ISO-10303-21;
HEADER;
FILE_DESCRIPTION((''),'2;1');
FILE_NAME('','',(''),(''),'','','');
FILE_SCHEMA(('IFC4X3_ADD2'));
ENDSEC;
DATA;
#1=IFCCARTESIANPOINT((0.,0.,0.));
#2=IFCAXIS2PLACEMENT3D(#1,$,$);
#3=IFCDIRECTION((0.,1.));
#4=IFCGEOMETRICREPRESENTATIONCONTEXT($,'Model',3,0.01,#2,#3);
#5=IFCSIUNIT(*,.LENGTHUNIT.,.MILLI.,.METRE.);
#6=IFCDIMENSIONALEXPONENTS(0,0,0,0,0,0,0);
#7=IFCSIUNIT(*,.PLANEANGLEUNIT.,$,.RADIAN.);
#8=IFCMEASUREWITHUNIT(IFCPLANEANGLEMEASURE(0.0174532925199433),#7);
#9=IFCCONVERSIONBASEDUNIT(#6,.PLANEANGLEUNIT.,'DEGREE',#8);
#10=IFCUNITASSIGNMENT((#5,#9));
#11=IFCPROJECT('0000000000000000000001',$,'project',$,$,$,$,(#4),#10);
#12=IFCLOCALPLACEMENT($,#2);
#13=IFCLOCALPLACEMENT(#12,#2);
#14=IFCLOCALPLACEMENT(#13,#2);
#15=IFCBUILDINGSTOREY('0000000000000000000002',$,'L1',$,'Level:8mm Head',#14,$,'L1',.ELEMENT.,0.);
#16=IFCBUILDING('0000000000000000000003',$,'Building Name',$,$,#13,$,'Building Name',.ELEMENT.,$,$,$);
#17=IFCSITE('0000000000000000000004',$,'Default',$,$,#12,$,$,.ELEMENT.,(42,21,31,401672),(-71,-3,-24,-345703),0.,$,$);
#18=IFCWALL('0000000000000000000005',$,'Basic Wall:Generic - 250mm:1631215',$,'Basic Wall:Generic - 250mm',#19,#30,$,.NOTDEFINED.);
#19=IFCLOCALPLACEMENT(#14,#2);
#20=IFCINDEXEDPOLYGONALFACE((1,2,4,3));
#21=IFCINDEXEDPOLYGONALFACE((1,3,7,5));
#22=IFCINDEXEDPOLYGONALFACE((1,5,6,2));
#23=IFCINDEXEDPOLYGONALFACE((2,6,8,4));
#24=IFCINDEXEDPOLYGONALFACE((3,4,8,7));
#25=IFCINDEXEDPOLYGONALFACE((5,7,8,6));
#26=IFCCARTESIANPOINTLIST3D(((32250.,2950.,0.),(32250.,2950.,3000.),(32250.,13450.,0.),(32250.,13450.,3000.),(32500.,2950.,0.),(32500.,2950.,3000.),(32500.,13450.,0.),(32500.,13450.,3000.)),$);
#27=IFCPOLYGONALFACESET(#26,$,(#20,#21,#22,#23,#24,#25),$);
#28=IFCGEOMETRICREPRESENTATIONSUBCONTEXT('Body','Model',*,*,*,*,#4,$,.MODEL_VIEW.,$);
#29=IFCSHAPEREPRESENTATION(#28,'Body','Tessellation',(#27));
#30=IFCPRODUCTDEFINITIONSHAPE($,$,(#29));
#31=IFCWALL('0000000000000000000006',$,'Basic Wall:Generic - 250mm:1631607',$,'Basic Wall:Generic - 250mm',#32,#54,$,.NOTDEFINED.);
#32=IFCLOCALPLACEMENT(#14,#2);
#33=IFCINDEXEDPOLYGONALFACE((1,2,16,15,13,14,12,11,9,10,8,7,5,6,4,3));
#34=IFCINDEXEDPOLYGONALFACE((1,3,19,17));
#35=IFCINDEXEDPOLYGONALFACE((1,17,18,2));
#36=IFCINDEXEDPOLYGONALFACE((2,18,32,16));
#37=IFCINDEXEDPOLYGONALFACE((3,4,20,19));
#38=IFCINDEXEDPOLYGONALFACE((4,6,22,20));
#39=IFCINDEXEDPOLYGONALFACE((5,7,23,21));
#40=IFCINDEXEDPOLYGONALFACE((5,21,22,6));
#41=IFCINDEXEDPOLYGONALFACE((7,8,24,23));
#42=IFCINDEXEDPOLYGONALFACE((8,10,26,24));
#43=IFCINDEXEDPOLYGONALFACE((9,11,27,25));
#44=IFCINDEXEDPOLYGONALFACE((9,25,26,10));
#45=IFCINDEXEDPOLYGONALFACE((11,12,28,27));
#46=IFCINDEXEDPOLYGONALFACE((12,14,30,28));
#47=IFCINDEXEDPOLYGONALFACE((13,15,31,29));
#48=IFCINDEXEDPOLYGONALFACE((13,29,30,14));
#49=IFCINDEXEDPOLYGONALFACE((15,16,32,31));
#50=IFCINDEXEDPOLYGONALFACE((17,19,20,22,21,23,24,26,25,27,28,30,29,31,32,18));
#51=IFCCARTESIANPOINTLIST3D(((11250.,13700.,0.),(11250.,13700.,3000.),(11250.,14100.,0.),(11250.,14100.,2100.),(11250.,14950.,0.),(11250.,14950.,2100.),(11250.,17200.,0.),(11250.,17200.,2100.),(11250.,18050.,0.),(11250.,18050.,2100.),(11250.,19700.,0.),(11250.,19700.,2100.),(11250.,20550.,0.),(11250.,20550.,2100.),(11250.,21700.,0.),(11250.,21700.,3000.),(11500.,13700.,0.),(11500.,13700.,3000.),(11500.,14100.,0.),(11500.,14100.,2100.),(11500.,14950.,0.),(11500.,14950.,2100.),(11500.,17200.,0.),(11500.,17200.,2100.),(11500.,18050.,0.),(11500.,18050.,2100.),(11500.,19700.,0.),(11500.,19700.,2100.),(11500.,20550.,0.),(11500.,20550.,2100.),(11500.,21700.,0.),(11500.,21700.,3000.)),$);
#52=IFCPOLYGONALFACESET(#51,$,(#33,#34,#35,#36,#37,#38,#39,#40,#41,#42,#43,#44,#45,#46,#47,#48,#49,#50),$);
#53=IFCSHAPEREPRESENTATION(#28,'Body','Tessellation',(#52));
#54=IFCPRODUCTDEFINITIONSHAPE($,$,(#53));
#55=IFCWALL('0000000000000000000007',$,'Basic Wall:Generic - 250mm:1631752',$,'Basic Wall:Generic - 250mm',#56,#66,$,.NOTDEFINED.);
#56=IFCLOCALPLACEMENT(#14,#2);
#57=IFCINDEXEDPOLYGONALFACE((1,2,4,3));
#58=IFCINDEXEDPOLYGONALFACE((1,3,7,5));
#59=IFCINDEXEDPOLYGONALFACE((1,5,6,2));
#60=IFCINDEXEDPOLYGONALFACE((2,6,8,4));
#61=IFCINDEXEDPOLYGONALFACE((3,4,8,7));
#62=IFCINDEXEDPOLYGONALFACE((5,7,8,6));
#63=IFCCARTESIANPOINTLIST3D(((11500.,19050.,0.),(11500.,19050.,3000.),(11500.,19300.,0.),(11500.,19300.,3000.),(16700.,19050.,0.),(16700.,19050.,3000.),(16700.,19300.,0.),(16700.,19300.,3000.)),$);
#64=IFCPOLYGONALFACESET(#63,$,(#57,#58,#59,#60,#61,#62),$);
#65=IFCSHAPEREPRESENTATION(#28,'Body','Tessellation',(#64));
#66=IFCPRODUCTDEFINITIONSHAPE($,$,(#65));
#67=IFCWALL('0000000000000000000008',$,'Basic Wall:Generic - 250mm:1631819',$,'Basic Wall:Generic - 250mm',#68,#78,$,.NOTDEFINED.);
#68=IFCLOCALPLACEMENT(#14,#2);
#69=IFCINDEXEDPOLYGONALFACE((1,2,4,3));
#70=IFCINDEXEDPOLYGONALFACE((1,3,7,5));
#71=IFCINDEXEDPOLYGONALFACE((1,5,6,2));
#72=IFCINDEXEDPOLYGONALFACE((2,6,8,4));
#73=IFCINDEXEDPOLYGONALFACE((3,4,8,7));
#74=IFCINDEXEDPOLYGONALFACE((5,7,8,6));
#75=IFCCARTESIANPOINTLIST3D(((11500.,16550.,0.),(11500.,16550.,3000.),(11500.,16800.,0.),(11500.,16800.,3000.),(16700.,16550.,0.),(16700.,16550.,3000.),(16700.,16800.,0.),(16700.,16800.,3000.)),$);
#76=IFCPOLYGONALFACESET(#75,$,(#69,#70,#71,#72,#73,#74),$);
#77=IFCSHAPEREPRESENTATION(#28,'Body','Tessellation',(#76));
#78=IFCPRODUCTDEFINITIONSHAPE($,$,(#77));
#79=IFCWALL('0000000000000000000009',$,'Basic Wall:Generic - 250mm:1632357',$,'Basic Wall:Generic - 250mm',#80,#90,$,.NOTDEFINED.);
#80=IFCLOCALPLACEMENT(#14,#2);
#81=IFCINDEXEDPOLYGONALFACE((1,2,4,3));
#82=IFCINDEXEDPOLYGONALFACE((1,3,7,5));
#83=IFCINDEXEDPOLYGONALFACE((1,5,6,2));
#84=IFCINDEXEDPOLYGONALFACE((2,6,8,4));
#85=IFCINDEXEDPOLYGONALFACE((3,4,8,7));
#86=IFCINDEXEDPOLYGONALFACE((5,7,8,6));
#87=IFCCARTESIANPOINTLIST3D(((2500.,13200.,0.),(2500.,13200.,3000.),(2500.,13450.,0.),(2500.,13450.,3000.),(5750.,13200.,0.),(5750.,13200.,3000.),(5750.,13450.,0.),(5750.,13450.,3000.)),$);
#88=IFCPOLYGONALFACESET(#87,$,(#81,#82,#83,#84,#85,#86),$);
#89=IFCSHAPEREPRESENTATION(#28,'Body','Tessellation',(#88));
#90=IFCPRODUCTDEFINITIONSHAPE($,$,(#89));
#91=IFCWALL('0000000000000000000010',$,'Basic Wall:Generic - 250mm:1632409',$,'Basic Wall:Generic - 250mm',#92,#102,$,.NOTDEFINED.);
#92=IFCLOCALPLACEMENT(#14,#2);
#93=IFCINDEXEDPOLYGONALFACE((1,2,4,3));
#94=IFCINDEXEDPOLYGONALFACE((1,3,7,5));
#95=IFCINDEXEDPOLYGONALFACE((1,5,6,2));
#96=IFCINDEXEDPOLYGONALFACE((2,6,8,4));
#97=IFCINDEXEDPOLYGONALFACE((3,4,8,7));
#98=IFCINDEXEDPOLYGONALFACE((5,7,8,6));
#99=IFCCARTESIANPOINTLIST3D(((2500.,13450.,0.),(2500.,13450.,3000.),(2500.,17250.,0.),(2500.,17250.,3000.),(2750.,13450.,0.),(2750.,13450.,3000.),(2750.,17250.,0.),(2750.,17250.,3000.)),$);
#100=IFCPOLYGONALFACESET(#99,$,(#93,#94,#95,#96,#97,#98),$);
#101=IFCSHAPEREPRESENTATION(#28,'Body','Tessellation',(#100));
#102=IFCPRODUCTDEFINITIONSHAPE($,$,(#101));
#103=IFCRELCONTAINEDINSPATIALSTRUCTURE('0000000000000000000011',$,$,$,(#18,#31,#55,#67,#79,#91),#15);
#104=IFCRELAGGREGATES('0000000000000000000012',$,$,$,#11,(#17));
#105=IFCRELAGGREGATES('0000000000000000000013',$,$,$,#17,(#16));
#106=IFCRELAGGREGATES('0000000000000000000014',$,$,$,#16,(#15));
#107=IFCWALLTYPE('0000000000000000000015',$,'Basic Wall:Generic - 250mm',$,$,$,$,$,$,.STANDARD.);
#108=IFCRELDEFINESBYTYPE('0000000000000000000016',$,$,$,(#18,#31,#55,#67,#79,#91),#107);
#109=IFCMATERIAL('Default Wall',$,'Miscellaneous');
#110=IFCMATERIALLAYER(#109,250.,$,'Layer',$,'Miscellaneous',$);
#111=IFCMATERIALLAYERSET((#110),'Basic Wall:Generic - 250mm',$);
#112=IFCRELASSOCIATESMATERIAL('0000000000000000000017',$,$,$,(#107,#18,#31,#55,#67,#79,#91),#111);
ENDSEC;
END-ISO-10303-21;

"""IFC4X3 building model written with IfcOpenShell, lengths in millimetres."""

from ifc_helpers import new_model, entity, si_unit, converted_unit, direction, frame, frame_2d, origin, place, context, subcontext, project, spatial, rectangle, extrude, material, layer, layer_set, type_object, element, save


model = new_model("IFC4X3")

# Units and contexts
model_context = context("Model", 3, precision=0.01, world=origin(), true_north=direction((0.0, 1.0)))
body_context = subcontext(model_context, "Body", "Model", "MODEL_VIEW")
ifc_project = project(units=[si_unit("LENGTHUNIT", "METRE", prefix="MILLI"), converted_unit("PLANEANGLEUNIT", "DEGREE", entity("IfcPlaneAngleMeasure", 0.0174532925199433), si_unit("PLANEANGLEUNIT", "RADIAN"), dimensions=[0, 0, 0, 0, 0, 0, 0])], contexts=[model_context])

# Site, building, storey
site_placement = place(None, origin())
site = spatial("IfcSite", under=ifc_project, at=site_placement, Name="Default", CompositionType="ELEMENT", RefLatitude=(42, 21, 31, 401672), RefLongitude=(-71, -3, -24, -345703), RefElevation=0.0)
building_placement = place(site_placement, origin())
building = spatial("IfcBuilding", under=site, at=building_placement, Name="Building Name", LongName="Building Name", CompositionType="ELEMENT")
storey_placement = place(building_placement, origin())
storey = spatial("IfcBuildingStorey", under=building, at=storey_placement, Name="L1", ObjectType="Level:8mm Head", LongName="L1", CompositionType="ELEMENT", Elevation=0.0)

# Shared definitions
ifc_material = material(Name="Default Wall", Category="Miscellaneous")
ifc_layer = layer(ifc_material, 250.0, Name="Layer", Category="Miscellaneous")
ifc_layer_set = layer_set([ifc_layer], Name="Basic Wall:Generic - 250mm")
wall_type = type_object("IfcWallType", Name="Basic Wall:Generic - 250mm", PredefinedType="STANDARD", material=ifc_layer_set)

# Wall
wall_1_placement = place(storey_placement, frame((32375.0, 2950.0, 0.0), z_axis=(0.0, 0.0, 1.0), x_axis=(0.0, 1.0, 0.0)))
element("IfcWall", 1, at=wall_1_placement, inside=storey, type_object=wall_type, material=ifc_layer_set, Name="Basic Wall:Generic - 250mm:1631215", ObjectType="Basic Wall:Generic - 250mm", PredefinedType="NOTDEFINED", context=body_context, shape_type="SweptSolid", body=[
    extrude(rectangle(XDim=10500.0, YDim=250.0, at=frame_2d((5250.0, 0.0), x_axis=(-1.0, 0.0))), origin(), (0.0, 0.0, 1.0), 3000.0),
])

# Wall, openings
wall_2_placement = place(storey_placement, frame((11375.0, 13700.0, 0.0), z_axis=(0.0, 0.0, 1.0), x_axis=(0.0, 1.0, 0.0)))
wall_2 = element("IfcWall", 2, at=wall_2_placement, inside=storey, type_object=wall_type, material=ifc_layer_set, Name="Basic Wall:Generic - 250mm:1631607", ObjectType="Basic Wall:Generic - 250mm", PredefinedType="NOTDEFINED", context=body_context, shape_type="SweptSolid", body=[
    extrude(rectangle(XDim=8000.0, YDim=250.0, at=frame_2d((4000.0, 0.0), x_axis=(-1.0, 0.0))), origin(), (0.0, 0.0, 1.0), 3000.0),
])
opening_1_placement = place(wall_2_placement, frame((6850.0, 125.0, 0.0)))
element("IfcOpeningElement", 3, at=opening_1_placement, cuts=wall_2, PredefinedType="OPENING", context=body_context, shape_type="SweptSolid", body=[
    extrude(rectangle(XDim=2100.0, YDim=850.0, at=frame_2d((1050.0, 425.0), x_axis=(1.0, 0.0))), frame((0.0, 0.0, 0.0), z_axis=(0.0, -1.0, 0.0), x_axis=(0.0, 0.0, 1.0)), (0.0, 0.0, 1.0), 250.0),
])
opening_2_placement = place(wall_2_placement, frame((4350.0, 125.0, 0.0)))
element("IfcOpeningElement", 4, at=opening_2_placement, cuts=wall_2, PredefinedType="OPENING", context=body_context, shape_type="SweptSolid", body=[
    extrude(rectangle(XDim=2100.0, YDim=850.0, at=frame_2d((1050.0, 425.0), x_axis=(1.0, 0.0))), frame((0.0, 0.0, 0.0), z_axis=(0.0, -1.0, 0.0), x_axis=(0.0, 0.0, 1.0)), (0.0, 0.0, 1.0), 250.0),
])
opening_3_placement = place(wall_2_placement, frame((1250.0, 125.0, 0.0)))
element("IfcOpeningElement", 5, at=opening_3_placement, cuts=wall_2, PredefinedType="OPENING", context=body_context, shape_type="SweptSolid", body=[
    extrude(rectangle(XDim=2100.0, YDim=850.0, at=frame_2d((1050.0, 425.0), x_axis=(1.0, 0.0))), frame((0.0, 0.0, 0.0), z_axis=(0.0, -1.0, 0.0), x_axis=(0.0, 0.0, 1.0)), (0.0, 0.0, 1.0), 250.0),
])

# Walls
wall_3_placement = place(storey_placement, frame((11500.0, 19175.0, 0.0)))
element("IfcWall", 6, at=wall_3_placement, inside=storey, type_object=wall_type, material=ifc_layer_set, Name="Basic Wall:Generic - 250mm:1631752", ObjectType="Basic Wall:Generic - 250mm", PredefinedType="NOTDEFINED", context=body_context, shape_type="SweptSolid", body=[
    extrude(rectangle(XDim=5200.0, YDim=250.0, at=frame_2d((2600.0, 0.0), x_axis=(-1.0, 0.0))), origin(), (0.0, 0.0, 1.0), 3000.0),
])
wall_4_placement = place(storey_placement, frame((11500.0, 16675.0, 0.0)))
element("IfcWall", 7, at=wall_4_placement, inside=storey, type_object=wall_type, material=ifc_layer_set, Name="Basic Wall:Generic - 250mm:1631819", ObjectType="Basic Wall:Generic - 250mm", PredefinedType="NOTDEFINED", context=body_context, shape_type="SweptSolid", body=[
    extrude(rectangle(XDim=5200.0, YDim=250.0, at=frame_2d((2600.0, 0.0), x_axis=(-1.0, 0.0))), origin(), (0.0, 0.0, 1.0), 3000.0),
])
wall_5_placement = place(storey_placement, frame((5750.0, 13325.0, 0.0), z_axis=(0.0, 0.0, 1.0), x_axis=(-1.0, 0.0, 0.0)))
element("IfcWall", 8, at=wall_5_placement, inside=storey, type_object=wall_type, material=ifc_layer_set, Name="Basic Wall:Generic - 250mm:1632357", ObjectType="Basic Wall:Generic - 250mm", PredefinedType="NOTDEFINED", context=body_context, shape_type="SweptSolid", body=[
    extrude(rectangle(XDim=3250.0, YDim=250.0, at=frame_2d((1625.0, 0.0), x_axis=(-1.0, 0.0))), origin(), (0.0, 0.0, 1.0), 3000.0),
])
wall_6_placement = place(storey_placement, frame((2625.0, 13450.0, 0.0), z_axis=(0.0, 0.0, 1.0), x_axis=(0.0, 1.0, 0.0)))
element("IfcWall", 9, at=wall_6_placement, inside=storey, type_object=wall_type, material=ifc_layer_set, Name="Basic Wall:Generic - 250mm:1632409", ObjectType="Basic Wall:Generic - 250mm", PredefinedType="NOTDEFINED", context=body_context, shape_type="SweptSolid", body=[
    extrude(rectangle(XDim=3800.0, YDim=250.0, at=frame_2d((1900.0, 0.0), x_axis=(-1.0, 0.0))), origin(), (0.0, 0.0, 1.0), 3000.0),
])

save(model, "model.ifc")
